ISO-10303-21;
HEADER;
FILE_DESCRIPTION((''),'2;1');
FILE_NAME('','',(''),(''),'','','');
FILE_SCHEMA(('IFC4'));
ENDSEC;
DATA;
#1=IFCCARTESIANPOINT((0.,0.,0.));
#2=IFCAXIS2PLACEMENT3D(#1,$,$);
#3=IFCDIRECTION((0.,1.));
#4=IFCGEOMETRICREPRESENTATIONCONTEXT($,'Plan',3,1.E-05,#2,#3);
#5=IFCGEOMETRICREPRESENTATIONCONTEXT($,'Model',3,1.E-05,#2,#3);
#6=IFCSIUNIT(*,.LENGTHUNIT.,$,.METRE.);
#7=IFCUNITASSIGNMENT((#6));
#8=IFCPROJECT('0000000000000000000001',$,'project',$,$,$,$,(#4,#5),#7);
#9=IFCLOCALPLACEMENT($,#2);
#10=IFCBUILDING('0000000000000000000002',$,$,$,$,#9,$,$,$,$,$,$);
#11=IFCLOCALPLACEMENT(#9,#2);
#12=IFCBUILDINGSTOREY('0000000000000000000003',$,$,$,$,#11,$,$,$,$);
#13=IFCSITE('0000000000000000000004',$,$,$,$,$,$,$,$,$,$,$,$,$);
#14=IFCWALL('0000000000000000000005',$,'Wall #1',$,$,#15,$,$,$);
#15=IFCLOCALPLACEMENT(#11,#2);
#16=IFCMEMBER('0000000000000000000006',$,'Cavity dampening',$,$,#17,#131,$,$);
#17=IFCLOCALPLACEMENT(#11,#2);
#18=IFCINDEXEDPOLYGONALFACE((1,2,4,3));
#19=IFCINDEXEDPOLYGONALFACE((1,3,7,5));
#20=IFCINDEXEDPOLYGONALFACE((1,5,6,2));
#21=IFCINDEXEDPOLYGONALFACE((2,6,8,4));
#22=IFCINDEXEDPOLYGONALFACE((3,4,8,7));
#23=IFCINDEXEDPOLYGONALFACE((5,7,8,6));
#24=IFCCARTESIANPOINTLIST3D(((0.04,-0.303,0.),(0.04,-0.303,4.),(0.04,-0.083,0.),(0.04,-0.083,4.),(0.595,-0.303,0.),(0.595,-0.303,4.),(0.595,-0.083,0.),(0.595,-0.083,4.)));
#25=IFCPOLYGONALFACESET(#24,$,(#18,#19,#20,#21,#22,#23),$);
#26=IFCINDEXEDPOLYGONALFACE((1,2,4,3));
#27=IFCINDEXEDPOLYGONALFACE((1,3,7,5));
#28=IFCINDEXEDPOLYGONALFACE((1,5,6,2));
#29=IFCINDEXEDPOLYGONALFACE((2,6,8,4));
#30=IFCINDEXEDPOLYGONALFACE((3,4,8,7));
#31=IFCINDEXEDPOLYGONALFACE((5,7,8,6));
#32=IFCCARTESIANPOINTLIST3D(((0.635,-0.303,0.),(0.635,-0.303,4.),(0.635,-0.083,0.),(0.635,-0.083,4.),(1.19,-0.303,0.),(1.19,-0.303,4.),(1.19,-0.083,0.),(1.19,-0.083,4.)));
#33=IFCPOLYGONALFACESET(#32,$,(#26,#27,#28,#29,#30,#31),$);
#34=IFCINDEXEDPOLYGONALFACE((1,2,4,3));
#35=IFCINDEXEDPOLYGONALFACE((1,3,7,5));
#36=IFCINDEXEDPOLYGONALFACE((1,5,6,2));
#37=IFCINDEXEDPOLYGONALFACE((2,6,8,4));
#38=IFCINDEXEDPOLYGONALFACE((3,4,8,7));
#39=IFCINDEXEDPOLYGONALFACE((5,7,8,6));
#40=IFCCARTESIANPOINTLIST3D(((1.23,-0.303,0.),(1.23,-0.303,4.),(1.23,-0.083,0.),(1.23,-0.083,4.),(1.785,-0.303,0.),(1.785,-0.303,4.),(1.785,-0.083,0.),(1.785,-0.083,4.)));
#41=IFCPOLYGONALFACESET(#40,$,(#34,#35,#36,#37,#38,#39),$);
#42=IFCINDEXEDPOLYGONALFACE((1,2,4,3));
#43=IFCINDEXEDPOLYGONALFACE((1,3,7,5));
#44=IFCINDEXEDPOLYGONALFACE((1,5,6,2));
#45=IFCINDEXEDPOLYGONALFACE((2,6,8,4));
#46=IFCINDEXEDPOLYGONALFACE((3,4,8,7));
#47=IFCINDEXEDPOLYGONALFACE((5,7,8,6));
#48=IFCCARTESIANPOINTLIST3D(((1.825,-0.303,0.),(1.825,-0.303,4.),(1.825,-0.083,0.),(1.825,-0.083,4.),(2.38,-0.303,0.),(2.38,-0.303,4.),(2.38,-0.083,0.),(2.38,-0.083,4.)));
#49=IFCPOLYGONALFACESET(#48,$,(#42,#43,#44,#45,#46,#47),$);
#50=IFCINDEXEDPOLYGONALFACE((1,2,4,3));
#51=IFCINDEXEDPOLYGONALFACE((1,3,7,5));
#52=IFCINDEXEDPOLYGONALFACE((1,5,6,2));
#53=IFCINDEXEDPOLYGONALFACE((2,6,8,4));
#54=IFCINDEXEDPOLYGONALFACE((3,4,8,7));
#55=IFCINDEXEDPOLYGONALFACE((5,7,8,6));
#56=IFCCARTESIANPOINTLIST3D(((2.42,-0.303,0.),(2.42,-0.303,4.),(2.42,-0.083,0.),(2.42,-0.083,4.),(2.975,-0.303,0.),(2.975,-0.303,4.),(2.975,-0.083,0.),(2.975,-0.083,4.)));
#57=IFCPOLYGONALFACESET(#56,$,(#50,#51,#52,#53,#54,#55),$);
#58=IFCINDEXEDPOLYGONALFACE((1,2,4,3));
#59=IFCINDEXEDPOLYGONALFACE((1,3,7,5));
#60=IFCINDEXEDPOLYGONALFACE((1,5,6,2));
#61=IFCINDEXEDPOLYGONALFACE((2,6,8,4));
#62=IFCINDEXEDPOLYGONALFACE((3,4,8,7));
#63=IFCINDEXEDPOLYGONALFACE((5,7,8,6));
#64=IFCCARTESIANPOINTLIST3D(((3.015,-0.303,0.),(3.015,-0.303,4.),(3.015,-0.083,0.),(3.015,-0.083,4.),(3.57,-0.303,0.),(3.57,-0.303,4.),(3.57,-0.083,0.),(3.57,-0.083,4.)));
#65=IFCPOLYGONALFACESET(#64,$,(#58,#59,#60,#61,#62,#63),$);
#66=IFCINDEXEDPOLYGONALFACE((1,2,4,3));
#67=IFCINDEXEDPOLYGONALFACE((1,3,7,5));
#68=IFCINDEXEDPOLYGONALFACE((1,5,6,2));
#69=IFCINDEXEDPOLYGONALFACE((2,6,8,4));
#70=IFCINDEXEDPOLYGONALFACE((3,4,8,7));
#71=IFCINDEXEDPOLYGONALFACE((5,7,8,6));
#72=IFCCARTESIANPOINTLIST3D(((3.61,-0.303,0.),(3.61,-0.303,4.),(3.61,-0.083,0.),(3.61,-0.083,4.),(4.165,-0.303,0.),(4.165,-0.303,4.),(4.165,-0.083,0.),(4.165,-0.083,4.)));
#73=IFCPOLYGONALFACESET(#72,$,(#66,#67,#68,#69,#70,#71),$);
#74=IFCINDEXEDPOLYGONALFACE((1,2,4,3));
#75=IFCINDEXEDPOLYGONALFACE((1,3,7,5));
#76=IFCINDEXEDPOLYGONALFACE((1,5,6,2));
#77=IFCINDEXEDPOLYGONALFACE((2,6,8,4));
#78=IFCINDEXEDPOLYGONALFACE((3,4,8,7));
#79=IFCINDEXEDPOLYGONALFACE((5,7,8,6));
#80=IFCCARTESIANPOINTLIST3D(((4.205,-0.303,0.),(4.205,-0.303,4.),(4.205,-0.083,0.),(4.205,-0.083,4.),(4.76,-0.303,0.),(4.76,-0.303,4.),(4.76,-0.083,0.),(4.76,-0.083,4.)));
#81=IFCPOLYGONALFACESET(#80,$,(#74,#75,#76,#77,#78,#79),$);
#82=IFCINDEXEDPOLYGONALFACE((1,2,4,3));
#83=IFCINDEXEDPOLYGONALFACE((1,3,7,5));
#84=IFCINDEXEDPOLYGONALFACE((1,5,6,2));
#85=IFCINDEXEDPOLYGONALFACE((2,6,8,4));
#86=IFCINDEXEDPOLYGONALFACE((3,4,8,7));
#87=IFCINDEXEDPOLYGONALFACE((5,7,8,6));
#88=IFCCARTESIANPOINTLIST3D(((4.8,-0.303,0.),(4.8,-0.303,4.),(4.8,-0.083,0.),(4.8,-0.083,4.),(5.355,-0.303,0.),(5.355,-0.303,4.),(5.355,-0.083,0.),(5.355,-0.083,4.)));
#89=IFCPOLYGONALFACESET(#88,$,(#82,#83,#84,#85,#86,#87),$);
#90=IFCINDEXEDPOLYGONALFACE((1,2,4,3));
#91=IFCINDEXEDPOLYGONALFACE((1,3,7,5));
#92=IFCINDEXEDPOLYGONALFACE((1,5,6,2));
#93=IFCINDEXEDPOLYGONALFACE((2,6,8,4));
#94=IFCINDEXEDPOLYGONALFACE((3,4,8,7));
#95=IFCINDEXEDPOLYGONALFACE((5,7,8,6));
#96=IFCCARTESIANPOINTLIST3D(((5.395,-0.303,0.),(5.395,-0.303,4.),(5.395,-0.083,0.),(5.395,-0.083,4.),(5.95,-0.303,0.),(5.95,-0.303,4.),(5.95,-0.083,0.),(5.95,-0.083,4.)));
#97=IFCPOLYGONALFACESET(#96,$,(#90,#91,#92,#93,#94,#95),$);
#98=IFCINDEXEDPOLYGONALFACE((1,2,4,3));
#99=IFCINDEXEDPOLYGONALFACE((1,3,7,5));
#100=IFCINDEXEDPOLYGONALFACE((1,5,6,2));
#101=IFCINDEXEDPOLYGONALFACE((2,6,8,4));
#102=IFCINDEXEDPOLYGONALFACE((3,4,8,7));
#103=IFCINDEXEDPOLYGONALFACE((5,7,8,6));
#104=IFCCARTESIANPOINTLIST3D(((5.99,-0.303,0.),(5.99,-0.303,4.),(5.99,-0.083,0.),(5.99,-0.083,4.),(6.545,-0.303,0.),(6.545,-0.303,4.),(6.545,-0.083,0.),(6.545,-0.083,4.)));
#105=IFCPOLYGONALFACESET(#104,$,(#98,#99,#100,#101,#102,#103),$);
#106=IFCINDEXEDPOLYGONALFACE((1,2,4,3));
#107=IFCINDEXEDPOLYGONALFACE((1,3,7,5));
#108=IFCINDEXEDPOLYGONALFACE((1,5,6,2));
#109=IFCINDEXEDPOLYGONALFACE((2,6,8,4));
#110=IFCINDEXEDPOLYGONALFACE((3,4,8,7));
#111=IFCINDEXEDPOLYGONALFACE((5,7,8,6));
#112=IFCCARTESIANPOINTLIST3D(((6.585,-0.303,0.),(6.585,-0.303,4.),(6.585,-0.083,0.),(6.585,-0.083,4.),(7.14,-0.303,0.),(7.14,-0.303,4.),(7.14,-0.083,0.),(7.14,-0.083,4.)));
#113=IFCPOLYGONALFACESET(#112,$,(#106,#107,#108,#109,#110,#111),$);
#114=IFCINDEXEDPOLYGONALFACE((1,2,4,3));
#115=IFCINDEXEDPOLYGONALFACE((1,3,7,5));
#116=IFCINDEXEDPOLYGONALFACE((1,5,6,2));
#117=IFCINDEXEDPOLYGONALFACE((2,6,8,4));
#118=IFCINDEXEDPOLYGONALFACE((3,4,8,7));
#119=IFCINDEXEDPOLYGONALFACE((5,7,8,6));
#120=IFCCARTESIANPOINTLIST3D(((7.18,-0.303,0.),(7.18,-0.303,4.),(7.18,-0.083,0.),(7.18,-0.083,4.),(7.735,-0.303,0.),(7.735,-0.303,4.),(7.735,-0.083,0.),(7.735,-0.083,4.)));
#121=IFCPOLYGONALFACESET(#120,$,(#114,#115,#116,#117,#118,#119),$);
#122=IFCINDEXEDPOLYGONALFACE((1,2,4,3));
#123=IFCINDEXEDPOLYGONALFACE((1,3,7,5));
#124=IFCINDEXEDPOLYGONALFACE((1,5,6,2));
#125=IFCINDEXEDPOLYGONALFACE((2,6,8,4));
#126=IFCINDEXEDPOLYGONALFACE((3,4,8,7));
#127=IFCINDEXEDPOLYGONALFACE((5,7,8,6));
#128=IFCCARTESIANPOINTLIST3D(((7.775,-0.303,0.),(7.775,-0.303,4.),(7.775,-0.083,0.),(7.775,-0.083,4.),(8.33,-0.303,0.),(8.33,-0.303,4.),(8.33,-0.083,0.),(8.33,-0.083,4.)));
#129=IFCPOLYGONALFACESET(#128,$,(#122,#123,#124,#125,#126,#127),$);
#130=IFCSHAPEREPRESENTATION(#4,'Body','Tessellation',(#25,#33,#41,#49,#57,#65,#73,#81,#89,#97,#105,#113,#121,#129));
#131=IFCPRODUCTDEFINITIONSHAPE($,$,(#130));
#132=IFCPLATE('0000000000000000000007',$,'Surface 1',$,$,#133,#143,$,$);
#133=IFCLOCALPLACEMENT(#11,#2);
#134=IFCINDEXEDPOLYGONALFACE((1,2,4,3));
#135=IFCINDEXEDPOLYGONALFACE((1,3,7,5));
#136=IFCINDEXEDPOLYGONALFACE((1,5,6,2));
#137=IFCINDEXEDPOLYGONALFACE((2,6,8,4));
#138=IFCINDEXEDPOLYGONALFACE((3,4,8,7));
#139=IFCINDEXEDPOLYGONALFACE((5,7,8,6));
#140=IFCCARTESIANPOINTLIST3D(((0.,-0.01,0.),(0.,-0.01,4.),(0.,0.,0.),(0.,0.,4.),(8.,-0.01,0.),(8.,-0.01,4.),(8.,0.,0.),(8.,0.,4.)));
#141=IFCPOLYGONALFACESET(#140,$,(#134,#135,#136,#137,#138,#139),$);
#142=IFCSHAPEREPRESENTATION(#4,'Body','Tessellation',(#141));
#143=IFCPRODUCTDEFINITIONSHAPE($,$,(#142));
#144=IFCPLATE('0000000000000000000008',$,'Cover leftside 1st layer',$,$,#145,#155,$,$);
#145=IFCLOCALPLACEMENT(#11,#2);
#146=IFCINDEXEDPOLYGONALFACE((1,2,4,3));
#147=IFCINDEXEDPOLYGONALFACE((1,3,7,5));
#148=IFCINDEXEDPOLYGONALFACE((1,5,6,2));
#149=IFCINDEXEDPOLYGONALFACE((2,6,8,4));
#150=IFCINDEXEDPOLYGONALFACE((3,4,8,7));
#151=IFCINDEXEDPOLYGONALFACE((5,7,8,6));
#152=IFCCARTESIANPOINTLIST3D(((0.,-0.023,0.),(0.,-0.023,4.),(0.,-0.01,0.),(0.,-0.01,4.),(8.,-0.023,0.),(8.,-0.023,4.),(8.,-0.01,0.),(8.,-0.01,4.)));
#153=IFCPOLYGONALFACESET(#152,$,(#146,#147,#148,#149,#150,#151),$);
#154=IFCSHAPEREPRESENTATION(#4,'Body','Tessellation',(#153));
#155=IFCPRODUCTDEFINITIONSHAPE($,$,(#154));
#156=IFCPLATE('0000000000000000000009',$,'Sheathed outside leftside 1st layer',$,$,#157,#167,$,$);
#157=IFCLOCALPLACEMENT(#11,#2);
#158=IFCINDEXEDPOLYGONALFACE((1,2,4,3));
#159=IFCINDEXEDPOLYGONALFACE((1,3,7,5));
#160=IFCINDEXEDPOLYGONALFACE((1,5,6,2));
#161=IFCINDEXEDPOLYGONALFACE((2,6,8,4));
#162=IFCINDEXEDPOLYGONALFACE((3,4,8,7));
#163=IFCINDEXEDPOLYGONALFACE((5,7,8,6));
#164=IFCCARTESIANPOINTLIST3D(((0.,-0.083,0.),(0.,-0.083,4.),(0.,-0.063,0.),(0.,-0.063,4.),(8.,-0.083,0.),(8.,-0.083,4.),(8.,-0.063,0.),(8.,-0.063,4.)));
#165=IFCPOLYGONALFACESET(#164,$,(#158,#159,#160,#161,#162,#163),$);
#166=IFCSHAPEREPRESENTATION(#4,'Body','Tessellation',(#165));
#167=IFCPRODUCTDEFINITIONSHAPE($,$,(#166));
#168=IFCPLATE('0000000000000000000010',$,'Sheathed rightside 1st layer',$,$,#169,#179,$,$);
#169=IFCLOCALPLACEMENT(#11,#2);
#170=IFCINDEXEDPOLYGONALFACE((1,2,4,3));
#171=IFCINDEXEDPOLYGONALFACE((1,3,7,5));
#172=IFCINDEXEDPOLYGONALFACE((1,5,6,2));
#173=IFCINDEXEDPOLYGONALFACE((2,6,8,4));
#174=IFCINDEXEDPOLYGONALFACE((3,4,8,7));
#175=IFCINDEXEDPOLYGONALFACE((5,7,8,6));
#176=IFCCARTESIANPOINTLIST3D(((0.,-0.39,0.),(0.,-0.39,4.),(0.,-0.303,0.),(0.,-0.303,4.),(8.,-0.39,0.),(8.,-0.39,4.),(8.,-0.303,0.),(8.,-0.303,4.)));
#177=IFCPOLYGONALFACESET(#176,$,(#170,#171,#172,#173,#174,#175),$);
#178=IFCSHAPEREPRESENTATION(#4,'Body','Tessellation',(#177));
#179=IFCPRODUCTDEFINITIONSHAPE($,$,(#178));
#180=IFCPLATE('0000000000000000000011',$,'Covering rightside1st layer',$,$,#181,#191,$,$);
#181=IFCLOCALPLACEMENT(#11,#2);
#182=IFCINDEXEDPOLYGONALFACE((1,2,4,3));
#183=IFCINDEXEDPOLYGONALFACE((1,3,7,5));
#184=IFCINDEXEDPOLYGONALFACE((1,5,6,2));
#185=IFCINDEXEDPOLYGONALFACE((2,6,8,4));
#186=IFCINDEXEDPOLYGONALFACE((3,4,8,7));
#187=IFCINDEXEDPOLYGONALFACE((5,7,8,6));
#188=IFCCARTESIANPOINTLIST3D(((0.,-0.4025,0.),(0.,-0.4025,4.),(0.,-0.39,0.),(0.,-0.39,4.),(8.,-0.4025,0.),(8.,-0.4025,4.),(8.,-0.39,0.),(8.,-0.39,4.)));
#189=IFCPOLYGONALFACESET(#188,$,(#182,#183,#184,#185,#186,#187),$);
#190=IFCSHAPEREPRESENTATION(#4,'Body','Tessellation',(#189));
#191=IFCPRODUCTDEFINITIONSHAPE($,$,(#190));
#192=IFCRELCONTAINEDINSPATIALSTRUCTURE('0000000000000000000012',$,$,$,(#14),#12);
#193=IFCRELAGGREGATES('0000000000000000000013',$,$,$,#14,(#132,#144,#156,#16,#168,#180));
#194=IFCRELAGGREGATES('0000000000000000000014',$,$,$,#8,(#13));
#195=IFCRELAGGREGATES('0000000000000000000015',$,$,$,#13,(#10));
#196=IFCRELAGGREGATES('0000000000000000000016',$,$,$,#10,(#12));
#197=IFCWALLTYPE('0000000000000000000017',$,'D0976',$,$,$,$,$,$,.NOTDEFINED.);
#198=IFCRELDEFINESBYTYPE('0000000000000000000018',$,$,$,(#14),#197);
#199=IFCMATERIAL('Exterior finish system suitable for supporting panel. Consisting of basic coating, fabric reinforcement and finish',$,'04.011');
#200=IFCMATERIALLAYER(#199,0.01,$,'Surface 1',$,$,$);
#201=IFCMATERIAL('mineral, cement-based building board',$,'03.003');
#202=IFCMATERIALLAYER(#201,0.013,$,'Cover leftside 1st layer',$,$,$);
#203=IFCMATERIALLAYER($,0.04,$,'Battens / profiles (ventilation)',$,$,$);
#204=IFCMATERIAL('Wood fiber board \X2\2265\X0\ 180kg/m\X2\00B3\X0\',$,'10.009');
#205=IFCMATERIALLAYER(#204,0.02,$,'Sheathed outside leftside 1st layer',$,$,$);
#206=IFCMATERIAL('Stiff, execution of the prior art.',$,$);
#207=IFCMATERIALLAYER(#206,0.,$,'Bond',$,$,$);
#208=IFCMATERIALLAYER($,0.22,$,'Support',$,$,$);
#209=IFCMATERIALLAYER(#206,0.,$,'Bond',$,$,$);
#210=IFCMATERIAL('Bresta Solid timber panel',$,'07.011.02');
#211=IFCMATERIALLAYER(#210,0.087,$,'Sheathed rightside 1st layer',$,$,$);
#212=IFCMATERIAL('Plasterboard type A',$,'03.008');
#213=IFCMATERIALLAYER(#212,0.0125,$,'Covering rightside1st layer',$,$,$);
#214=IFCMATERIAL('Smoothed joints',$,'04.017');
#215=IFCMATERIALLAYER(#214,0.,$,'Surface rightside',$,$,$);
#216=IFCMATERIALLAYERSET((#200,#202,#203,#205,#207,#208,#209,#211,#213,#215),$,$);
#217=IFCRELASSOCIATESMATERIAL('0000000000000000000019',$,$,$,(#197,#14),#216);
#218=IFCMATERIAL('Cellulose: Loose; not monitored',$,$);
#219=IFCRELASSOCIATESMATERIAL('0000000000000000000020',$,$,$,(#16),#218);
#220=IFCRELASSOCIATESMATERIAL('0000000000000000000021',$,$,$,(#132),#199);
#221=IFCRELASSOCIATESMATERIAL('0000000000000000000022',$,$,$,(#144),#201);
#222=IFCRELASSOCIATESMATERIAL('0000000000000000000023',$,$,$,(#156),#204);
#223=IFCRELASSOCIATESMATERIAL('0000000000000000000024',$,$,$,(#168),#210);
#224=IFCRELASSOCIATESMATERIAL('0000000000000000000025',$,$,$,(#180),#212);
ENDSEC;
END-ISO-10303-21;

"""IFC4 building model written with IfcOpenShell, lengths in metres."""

from ifc_helpers import new_model, si_unit, direction, frame, frame_2d, origin, origin_with_axes, place, context, project, spatial, rectangle, extrude, material, layer, layer_set, type_object, element, aggregate, save


model = new_model("IFC4")

# Units and contexts
plan_context = context("Plan", 3, precision=1e-05, world=origin(), true_north=direction((0.0, 1.0)))
model_context = context("Model", 3, precision=1e-05, world=origin(), true_north=direction((0.0, 1.0)))
ifc_project = project(units=[si_unit("LENGTHUNIT", "METRE")], contexts=[plan_context, model_context])

# Site, building, storey
site = spatial("IfcSite", under=ifc_project)
building_placement = place(None, origin())
building = spatial("IfcBuilding", under=site, at=building_placement)
storey_placement = place(building_placement, origin())
storey = spatial("IfcBuildingStorey", under=building, at=storey_placement)

# Wall, member, plates
ifc_material_1 = material(Name="Exterior finish system suitable for supporting panel. Consisting of basic coating, fabric reinforcement and finish", Category="04.011")
ifc_layer_1 = layer(ifc_material_1, 0.01, Name="Surface 1")
ifc_material_2 = material(Name="mineral, cement-based building board", Category="03.003")
ifc_layer_2 = layer(ifc_material_2, 0.013, Name="Cover leftside 1st layer")
ifc_layer_3 = layer(None, 0.04, Name="Battens / profiles (ventilation)")
ifc_material_3 = material(Name="Wood fiber board ≥ 180kg/m³", Category="10.009")
ifc_layer_4 = layer(ifc_material_3, 0.02, Name="Sheathed outside leftside 1st layer")
ifc_material_4 = material(Name="Stiff, execution of the prior art.")
ifc_layer_5 = layer(ifc_material_4, 0.0, Name="Bond")
ifc_layer_6 = layer(None, 0.22, Name="Support")
ifc_layer_7 = layer(ifc_material_4, 0.0, Name="Bond")
ifc_material_5 = material(Name="Bresta Solid timber panel", Category="07.011.02")
ifc_layer_8 = layer(ifc_material_5, 0.087, Name="Sheathed rightside 1st layer")
ifc_material_6 = material(Name="Plasterboard type A", Category="03.008")
ifc_layer_9 = layer(ifc_material_6, 0.0125, Name="Covering rightside1st layer")
ifc_material_7 = material(Name="Smoothed joints", Category="04.017")
ifc_layer_10 = layer(ifc_material_7, 0.0, Name="Surface rightside")
ifc_layer_set = layer_set([ifc_layer_1, ifc_layer_2, ifc_layer_3, ifc_layer_4, ifc_layer_5, ifc_layer_6, ifc_layer_7, ifc_layer_8, ifc_layer_9, ifc_layer_10])
wall_type = type_object("IfcWallType", Name="D0976", PredefinedType="NOTDEFINED", material=ifc_layer_set)
wall_placement = place(None, frame((0.0, 0.0, 0.0), z_axis=(0.0, -1.0, 0.0), x_axis=(1.0, 0.0, 0.0)))
wall = element("IfcWall", 1, at=wall_placement, inside=storey, type_object=wall_type, material=ifc_layer_set, Name="Wall #1")
ifc_material_8 = material(Name="Cellulose: Loose; not monitored")
member_1_placement = place(wall_placement, origin())
member_1 = element("IfcMember", 2, at=member_1_placement, material=ifc_material_8, Name="Cavity dampening", context=plan_context, shape_type="SweptSolid", body=[
    extrude(rectangle(XDim=0.555, YDim=0.22, at=frame_2d((0.2775, 0.11), x_axis=(1.0, 0.0))), frame((0.04, 4.0, 0.083), z_axis=(0.0, -1.0, 0.0), x_axis=(1.0, 0.0, 0.0)), (0.0, 0.0, 1.0), 4.0),
    extrude(rectangle(XDim=0.555, YDim=0.22, at=frame_2d((0.2775, 0.11), x_axis=(1.0, 0.0))), frame((0.635, 4.0, 0.083), z_axis=(0.0, -1.0, 0.0), x_axis=(1.0, 0.0, 0.0)), (0.0, 0.0, 1.0), 4.0),
    extrude(rectangle(XDim=0.555, YDim=0.22, at=frame_2d((0.2775, 0.11), x_axis=(1.0, 0.0))), frame((1.23, 4.0, 0.083), z_axis=(0.0, -1.0, 0.0), x_axis=(1.0, 0.0, 0.0)), (0.0, 0.0, 1.0), 4.0),
    extrude(rectangle(XDim=0.555, YDim=0.22, at=frame_2d((0.2775, 0.11), x_axis=(1.0, 0.0))), frame((1.825, 4.0, 0.083), z_axis=(0.0, -1.0, 0.0), x_axis=(1.0, 0.0, 0.0)), (0.0, 0.0, 1.0), 4.0),
    extrude(rectangle(XDim=0.555, YDim=0.22, at=frame_2d((0.2775, 0.11), x_axis=(1.0, 0.0))), frame((2.42, 4.0, 0.083), z_axis=(0.0, -1.0, 0.0), x_axis=(1.0, 0.0, 0.0)), (0.0, 0.0, 1.0), 4.0),
    extrude(rectangle(XDim=0.555, YDim=0.22, at=frame_2d((0.2775, 0.11), x_axis=(1.0, 0.0))), frame((3.015, 4.0, 0.083), z_axis=(0.0, -1.0, 0.0), x_axis=(1.0, 0.0, 0.0)), (0.0, 0.0, 1.0), 4.0),
    extrude(rectangle(XDim=0.555, YDim=0.22, at=frame_2d((0.2775, 0.11), x_axis=(1.0, 0.0))), frame((3.61, 4.0, 0.083), z_axis=(0.0, -1.0, 0.0), x_axis=(1.0, 0.0, 0.0)), (0.0, 0.0, 1.0), 4.0),
    extrude(rectangle(XDim=0.555, YDim=0.22, at=frame_2d((0.2775, 0.11), x_axis=(1.0, 0.0))), frame((4.205, 4.0, 0.083), z_axis=(0.0, -1.0, 0.0), x_axis=(1.0, 0.0, 0.0)), (0.0, 0.0, 1.0), 4.0),
    extrude(rectangle(XDim=0.555, YDim=0.22, at=frame_2d((0.2775, 0.11), x_axis=(1.0, 0.0))), frame((4.8, 4.0, 0.083), z_axis=(0.0, -1.0, 0.0), x_axis=(1.0, 0.0, 0.0)), (0.0, 0.0, 1.0), 4.0),
    extrude(rectangle(XDim=0.555, YDim=0.22, at=frame_2d((0.2775, 0.11), x_axis=(1.0, 0.0))), frame((5.395, 4.0, 0.083), z_axis=(0.0, -1.0, 0.0), x_axis=(1.0, 0.0, 0.0)), (0.0, 0.0, 1.0), 4.0),
    extrude(rectangle(XDim=0.555, YDim=0.22, at=frame_2d((0.2775, 0.11), x_axis=(1.0, 0.0))), frame((5.99, 4.0, 0.083), z_axis=(0.0, -1.0, 0.0), x_axis=(1.0, 0.0, 0.0)), (0.0, 0.0, 1.0), 4.0),
    extrude(rectangle(XDim=0.555, YDim=0.22, at=frame_2d((0.2775, 0.11), x_axis=(1.0, 0.0))), frame((6.585, 4.0, 0.083), z_axis=(0.0, -1.0, 0.0), x_axis=(1.0, 0.0, 0.0)), (0.0, 0.0, 1.0), 4.0),
    extrude(rectangle(XDim=0.555, YDim=0.22, at=frame_2d((0.2775, 0.11), x_axis=(1.0, 0.0))), frame((7.18, 4.0, 0.083), z_axis=(0.0, -1.0, 0.0), x_axis=(1.0, 0.0, 0.0)), (0.0, 0.0, 1.0), 4.0),
    extrude(rectangle(XDim=0.555, YDim=0.22, at=frame_2d((0.2775, 0.11), x_axis=(1.0, 0.0))), frame((7.775, 4.0, 0.083), z_axis=(0.0, -1.0, 0.0), x_axis=(1.0, 0.0, 0.0)), (0.0, 0.0, 1.0), 4.0),
])
plate_1_placement = place(wall_placement, origin())
plate_1 = element("IfcPlate", 3, at=plate_1_placement, material=ifc_material_1, Name="Surface 1", context=plan_context, shape_type="SweptSolid", body=[
    extrude(rectangle(XDim=8.0, YDim=4.0, at=frame_2d((4.0, 2.0), x_axis=(1.0, 0.0))), origin_with_axes(), (0.0, 0.0, 1.0), 0.01),
])
plate_2_placement = place(wall_placement, origin())
plate_2 = element("IfcPlate", 4, at=plate_2_placement, material=ifc_material_2, Name="Cover leftside 1st layer", context=plan_context, shape_type="SweptSolid", body=[
    extrude(rectangle(XDim=8.0, YDim=4.0, at=frame_2d((4.0, 2.0), x_axis=(1.0, 0.0))), frame((0.0, 0.0, 0.01), z_axis=(0.0, 0.0, 1.0), x_axis=(1.0, 0.0, 0.0)), (0.0, 0.0, 1.0), 0.013),
])
plate_3_placement = place(wall_placement, origin())
plate_3 = element("IfcPlate", 5, at=plate_3_placement, material=ifc_material_3, Name="Sheathed outside leftside 1st layer", context=plan_context, shape_type="SweptSolid", body=[
    extrude(rectangle(XDim=8.0, YDim=4.0, at=frame_2d((4.0, 2.0), x_axis=(1.0, 0.0))), frame((0.0, 0.0, 0.063), z_axis=(0.0, 0.0, 1.0), x_axis=(1.0, 0.0, 0.0)), (0.0, 0.0, 1.0), 0.02),
])
plate_4_placement = place(wall_placement, origin())
plate_4 = element("IfcPlate", 6, at=plate_4_placement, material=ifc_material_5, Name="Sheathed rightside 1st layer", context=plan_context, shape_type="SweptSolid", body=[
    extrude(rectangle(XDim=8.0, YDim=4.0, at=frame_2d((4.0, 2.0), x_axis=(1.0, 0.0))), frame((0.0, 0.0, 0.303), z_axis=(0.0, 0.0, 1.0), x_axis=(1.0, 0.0, 0.0)), (0.0, 0.0, 1.0), 0.087),
])
plate_5_placement = place(wall_placement, origin())
plate_5 = element("IfcPlate", 7, at=plate_5_placement, material=ifc_material_6, Name="Covering rightside1st layer", context=plan_context, shape_type="SweptSolid", body=[
    extrude(rectangle(XDim=8.0, YDim=4.0, at=frame_2d((4.0, 2.0), x_axis=(1.0, 0.0))), frame((0.0, 0.0, 0.39), z_axis=(0.0, 0.0, 1.0), x_axis=(1.0, 0.0, 0.0)), (0.0, 0.0, 1.0), 0.0125),
])
aggregate(wall, [plate_1, plate_2, plate_3, member_1, plate_4, plate_5])

save(model, "model.ifc")
